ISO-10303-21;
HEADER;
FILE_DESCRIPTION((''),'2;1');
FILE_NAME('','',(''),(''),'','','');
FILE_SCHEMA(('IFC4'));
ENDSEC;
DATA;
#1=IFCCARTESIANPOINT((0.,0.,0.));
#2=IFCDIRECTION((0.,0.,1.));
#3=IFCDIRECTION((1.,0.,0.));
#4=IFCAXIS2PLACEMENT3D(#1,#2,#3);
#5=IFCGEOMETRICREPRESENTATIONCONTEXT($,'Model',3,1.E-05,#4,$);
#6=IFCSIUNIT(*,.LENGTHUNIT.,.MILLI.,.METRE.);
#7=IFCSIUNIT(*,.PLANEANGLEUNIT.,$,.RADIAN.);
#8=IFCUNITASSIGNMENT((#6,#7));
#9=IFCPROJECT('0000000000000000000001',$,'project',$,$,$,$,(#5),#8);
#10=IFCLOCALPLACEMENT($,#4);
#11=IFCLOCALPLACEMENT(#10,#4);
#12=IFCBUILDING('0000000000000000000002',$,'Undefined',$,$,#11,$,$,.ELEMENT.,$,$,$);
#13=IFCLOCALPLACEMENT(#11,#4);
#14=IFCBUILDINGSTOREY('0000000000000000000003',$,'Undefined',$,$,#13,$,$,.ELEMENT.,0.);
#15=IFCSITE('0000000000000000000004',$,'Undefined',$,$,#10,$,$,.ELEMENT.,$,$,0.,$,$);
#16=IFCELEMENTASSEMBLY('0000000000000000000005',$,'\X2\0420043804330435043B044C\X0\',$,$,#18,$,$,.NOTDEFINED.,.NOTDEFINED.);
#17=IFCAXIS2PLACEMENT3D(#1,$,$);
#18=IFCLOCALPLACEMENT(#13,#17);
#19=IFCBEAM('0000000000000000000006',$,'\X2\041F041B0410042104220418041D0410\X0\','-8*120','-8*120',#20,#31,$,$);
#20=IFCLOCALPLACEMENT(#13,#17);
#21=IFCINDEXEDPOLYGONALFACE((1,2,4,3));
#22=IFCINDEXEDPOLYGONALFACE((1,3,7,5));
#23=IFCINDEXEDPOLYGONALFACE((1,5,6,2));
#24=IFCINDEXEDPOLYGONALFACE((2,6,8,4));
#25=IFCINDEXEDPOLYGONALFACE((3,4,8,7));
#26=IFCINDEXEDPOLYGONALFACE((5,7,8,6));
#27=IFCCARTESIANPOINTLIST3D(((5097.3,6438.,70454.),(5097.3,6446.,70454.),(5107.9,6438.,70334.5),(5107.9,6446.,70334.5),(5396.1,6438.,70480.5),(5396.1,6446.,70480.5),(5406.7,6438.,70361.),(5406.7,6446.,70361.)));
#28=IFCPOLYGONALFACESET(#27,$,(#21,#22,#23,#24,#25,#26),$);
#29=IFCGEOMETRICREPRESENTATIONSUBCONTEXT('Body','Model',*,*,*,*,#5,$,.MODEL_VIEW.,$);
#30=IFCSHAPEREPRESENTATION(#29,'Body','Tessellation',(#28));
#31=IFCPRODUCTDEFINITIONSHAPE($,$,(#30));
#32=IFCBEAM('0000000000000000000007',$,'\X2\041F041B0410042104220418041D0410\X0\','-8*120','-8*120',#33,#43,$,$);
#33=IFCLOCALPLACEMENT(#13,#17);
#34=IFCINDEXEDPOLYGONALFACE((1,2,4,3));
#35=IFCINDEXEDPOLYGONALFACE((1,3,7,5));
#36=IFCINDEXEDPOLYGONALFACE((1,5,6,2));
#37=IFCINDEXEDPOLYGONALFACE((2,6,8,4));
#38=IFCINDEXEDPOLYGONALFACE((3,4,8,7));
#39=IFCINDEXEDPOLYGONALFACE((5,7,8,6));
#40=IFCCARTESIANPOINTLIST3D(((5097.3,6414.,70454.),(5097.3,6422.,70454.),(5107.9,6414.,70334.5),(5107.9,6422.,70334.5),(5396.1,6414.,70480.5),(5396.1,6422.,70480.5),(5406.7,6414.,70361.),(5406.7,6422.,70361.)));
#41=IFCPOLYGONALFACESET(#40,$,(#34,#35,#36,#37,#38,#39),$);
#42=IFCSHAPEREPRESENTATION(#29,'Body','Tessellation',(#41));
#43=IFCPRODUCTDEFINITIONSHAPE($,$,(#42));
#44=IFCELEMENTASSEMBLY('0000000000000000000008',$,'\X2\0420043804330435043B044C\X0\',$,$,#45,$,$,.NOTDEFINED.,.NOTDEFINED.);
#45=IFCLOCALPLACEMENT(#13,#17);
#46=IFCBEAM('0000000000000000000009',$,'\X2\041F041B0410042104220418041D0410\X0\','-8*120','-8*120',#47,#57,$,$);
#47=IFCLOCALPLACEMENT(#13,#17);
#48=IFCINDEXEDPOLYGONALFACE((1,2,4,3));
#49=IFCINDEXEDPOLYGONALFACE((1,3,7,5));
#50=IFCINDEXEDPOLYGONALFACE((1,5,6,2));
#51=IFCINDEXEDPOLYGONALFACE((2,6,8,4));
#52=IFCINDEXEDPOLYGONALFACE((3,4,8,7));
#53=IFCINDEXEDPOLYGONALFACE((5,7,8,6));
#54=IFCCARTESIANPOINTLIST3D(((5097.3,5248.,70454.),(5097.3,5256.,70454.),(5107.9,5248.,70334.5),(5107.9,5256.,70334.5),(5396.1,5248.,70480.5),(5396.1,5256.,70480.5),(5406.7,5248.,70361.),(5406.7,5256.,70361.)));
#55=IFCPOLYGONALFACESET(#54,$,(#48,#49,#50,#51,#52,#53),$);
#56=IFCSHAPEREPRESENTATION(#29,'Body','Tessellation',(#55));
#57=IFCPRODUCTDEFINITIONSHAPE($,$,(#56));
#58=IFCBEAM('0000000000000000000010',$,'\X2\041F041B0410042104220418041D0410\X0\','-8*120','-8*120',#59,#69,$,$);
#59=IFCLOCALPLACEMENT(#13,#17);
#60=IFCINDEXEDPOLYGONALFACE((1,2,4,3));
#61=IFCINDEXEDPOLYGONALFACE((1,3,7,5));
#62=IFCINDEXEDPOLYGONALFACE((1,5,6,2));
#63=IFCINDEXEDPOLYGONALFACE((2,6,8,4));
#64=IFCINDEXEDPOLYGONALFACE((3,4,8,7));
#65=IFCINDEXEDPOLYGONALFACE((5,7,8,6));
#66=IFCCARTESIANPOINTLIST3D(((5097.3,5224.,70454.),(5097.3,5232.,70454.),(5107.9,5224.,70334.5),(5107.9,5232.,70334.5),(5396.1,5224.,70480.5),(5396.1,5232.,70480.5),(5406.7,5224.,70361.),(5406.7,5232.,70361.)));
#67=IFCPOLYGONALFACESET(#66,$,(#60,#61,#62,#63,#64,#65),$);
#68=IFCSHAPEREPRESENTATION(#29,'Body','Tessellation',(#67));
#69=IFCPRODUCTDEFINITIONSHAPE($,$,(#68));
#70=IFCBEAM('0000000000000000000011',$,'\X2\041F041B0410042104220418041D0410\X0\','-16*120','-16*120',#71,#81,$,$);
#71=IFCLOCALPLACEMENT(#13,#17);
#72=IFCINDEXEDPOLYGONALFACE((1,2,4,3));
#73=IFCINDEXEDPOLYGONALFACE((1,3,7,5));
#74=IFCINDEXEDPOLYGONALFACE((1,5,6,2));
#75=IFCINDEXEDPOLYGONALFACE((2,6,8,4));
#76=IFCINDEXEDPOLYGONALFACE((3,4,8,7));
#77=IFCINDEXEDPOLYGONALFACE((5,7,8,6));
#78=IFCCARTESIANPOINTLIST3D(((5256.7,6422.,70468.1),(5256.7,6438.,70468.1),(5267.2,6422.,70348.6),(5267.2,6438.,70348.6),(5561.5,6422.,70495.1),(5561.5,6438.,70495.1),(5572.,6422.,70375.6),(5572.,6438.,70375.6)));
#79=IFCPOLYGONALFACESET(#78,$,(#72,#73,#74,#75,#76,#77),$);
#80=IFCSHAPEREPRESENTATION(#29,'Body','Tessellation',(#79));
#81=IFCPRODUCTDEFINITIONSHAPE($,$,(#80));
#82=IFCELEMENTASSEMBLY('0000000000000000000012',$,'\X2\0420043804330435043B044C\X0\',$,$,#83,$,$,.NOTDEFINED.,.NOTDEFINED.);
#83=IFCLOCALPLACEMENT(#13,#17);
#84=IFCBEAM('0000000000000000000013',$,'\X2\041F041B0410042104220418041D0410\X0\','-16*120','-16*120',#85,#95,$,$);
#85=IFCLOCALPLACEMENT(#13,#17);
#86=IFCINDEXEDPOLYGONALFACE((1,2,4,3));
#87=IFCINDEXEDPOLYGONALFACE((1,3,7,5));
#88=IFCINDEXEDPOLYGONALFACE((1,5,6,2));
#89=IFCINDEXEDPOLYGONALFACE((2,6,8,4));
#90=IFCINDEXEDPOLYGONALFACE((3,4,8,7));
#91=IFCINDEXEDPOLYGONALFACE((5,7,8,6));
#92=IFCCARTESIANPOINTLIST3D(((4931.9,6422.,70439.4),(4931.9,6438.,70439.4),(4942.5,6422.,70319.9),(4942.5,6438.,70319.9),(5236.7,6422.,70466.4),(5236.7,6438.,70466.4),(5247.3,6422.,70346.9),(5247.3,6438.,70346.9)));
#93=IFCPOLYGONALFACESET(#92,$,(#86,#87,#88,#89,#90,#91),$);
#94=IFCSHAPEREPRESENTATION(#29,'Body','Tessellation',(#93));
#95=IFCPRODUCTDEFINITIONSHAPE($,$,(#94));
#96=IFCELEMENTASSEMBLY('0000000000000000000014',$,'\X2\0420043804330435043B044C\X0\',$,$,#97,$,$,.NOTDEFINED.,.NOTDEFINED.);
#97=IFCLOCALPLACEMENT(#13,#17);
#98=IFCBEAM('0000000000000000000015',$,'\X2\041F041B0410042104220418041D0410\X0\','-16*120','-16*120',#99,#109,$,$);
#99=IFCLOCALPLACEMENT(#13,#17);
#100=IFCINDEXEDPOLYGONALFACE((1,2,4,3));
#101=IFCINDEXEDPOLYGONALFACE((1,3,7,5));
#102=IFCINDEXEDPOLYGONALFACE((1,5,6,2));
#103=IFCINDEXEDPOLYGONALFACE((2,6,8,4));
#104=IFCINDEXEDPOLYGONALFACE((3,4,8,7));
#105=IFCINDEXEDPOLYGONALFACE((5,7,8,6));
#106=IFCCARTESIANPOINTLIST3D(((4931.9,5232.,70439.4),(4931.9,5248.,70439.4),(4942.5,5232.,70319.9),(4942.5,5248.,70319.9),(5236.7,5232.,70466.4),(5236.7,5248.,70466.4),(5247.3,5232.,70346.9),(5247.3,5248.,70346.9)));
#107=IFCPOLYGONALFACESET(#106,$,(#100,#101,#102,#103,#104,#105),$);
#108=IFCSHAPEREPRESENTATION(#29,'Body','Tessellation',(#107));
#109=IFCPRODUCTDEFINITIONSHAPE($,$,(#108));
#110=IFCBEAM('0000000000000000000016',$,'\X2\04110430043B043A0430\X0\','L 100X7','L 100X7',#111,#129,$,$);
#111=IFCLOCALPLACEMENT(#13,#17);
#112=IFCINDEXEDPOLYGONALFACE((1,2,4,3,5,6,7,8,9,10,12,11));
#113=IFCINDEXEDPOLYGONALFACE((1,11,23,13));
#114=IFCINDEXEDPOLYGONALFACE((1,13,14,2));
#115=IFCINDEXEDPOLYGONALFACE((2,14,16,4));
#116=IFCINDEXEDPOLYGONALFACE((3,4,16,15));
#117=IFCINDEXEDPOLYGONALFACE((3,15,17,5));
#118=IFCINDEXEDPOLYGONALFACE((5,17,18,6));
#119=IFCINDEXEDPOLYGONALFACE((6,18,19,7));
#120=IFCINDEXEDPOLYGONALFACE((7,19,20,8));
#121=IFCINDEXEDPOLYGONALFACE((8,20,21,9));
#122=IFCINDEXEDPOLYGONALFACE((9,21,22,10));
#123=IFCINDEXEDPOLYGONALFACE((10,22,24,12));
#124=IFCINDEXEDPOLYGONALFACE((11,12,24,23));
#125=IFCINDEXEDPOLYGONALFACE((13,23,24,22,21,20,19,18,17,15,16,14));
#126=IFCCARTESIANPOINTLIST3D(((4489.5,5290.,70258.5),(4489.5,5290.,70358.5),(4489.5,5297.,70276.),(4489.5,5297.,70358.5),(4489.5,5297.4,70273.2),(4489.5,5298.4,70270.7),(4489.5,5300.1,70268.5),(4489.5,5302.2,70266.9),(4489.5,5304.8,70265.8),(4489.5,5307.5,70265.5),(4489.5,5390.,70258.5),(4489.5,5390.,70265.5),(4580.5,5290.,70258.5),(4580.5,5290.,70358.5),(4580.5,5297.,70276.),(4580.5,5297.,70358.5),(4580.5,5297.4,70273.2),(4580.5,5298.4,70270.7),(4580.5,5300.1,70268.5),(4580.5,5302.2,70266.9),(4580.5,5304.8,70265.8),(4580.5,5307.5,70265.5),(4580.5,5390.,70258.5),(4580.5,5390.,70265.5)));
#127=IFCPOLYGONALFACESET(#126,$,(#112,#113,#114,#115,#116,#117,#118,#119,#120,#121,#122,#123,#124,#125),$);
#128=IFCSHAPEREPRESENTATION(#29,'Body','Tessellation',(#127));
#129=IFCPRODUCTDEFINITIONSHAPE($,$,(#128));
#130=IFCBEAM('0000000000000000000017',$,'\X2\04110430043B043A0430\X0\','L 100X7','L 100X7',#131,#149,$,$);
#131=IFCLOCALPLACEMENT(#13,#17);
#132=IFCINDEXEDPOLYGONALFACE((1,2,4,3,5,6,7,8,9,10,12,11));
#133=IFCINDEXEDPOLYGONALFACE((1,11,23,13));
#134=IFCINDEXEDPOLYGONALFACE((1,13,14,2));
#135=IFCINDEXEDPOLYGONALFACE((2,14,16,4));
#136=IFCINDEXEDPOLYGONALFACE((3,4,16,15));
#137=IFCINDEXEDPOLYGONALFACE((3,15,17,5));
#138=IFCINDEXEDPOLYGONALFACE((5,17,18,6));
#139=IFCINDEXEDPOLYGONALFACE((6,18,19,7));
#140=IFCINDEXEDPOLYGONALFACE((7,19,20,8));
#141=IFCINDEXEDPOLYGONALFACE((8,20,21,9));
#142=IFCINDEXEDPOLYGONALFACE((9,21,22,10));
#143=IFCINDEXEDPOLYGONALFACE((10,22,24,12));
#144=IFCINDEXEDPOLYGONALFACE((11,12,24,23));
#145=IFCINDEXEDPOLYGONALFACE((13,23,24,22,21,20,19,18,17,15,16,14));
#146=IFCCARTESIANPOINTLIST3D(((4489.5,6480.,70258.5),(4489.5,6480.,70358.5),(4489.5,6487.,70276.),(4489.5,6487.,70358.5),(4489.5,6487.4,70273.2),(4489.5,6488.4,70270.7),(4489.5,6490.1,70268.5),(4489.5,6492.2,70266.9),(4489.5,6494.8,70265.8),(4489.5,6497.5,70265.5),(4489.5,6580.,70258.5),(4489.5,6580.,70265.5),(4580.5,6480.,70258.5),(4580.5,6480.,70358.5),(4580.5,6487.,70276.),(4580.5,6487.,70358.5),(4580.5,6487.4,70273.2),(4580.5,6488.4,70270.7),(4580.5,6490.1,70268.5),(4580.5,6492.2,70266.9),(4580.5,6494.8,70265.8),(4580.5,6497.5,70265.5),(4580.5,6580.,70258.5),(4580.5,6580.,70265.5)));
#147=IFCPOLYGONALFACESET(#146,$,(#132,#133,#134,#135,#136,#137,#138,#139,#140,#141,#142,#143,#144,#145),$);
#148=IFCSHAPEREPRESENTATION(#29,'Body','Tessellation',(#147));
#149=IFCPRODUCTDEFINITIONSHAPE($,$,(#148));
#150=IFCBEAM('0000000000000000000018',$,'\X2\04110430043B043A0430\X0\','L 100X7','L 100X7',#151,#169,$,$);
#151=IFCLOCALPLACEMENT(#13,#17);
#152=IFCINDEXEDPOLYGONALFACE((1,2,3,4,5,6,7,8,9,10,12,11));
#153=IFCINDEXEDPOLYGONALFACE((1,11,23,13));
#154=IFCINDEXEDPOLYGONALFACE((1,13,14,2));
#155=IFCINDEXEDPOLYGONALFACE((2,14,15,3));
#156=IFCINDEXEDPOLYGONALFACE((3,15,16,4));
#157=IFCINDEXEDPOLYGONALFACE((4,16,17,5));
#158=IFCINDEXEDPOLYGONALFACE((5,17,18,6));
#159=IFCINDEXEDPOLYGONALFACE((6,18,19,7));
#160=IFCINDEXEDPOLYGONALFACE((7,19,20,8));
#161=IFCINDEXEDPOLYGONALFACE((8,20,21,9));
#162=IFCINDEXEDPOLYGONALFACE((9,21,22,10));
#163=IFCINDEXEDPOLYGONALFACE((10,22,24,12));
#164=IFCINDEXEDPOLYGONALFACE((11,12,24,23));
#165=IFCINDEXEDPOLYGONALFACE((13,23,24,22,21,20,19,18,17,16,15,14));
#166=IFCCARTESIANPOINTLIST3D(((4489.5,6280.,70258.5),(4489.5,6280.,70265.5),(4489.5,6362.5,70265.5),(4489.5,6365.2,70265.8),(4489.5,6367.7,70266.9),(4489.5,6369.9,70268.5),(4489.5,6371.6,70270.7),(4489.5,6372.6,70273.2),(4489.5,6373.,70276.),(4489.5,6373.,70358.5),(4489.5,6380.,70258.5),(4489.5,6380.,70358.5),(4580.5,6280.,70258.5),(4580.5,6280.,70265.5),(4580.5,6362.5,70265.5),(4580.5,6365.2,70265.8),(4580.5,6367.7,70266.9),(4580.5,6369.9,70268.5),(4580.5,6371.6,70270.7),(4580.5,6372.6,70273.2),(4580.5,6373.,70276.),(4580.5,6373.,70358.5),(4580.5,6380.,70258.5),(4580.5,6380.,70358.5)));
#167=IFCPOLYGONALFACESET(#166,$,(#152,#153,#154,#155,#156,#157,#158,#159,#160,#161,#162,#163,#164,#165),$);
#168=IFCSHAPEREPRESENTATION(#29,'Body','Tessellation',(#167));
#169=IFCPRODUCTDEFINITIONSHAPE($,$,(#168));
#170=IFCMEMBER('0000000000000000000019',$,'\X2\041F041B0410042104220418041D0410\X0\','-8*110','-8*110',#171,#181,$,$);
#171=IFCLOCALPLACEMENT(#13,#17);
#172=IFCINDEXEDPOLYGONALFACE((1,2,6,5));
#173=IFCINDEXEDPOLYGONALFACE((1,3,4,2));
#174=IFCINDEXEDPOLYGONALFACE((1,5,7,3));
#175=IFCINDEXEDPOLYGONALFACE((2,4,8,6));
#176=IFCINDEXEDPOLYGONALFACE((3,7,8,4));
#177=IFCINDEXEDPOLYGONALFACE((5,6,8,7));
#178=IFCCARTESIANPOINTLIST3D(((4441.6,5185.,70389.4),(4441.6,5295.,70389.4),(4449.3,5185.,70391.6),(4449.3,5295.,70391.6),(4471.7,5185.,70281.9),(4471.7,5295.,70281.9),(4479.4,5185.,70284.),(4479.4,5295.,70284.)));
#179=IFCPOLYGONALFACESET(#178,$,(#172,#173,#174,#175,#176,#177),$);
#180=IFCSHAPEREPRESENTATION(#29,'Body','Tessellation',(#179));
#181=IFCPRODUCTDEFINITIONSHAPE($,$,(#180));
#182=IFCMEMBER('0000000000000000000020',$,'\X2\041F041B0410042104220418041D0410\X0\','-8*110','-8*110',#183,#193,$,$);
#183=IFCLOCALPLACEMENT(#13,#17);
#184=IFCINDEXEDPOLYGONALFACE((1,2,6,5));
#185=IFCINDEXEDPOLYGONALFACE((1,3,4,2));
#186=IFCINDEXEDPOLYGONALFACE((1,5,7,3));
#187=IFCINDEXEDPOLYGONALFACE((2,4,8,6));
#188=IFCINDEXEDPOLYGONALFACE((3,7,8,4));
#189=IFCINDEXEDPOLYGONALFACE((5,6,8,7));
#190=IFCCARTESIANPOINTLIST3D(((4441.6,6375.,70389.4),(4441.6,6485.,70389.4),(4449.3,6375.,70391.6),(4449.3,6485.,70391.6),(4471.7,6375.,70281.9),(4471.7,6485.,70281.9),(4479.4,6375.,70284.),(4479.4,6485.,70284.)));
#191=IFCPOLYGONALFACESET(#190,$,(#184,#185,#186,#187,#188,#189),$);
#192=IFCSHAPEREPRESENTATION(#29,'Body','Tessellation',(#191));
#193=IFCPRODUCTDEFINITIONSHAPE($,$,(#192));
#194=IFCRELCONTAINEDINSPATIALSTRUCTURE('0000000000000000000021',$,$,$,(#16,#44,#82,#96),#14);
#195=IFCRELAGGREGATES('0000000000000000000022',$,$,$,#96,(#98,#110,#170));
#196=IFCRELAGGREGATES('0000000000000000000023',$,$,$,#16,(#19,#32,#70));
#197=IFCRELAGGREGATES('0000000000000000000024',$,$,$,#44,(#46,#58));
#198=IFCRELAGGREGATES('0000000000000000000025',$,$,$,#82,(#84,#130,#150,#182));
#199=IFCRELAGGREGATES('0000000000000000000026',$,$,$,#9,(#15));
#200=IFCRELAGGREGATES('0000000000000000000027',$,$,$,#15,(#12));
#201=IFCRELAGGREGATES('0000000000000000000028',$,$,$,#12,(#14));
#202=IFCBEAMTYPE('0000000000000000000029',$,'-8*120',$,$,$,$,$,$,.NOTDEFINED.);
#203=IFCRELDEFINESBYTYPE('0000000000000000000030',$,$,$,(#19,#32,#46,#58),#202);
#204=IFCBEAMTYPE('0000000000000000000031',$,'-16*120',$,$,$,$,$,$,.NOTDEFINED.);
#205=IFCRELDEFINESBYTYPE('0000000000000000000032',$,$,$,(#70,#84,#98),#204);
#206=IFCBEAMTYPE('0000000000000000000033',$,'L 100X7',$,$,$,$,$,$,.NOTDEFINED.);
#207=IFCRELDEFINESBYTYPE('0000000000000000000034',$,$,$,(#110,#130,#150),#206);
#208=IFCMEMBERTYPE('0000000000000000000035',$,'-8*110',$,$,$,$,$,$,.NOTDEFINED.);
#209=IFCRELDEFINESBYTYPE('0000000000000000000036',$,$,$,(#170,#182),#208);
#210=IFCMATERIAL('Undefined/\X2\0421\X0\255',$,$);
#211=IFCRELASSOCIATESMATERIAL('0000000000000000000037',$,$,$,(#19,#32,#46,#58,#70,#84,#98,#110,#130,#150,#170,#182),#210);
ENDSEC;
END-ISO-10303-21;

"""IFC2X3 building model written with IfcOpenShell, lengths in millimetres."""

from ifc_helpers import new_model, si_unit, frame, origin_with_axes, origin_2d_with_axis, place, context, subcontext, project, spatial, rectangle, l_section, extrude, material, type_object, element, aggregate, save


model = new_model("IFC2X3")

# Units and contexts
model_context = context("Model", 3, precision=1e-05, world=origin_with_axes())
body_context = subcontext(model_context, "Body", "Model", "MODEL_VIEW")
ifc_project = project(units=[si_unit("LENGTHUNIT", "METRE", prefix="MILLI"), si_unit("PLANEANGLEUNIT", "RADIAN")], contexts=[model_context])

# Site, building, storey
site_placement = place(None, origin_with_axes())
site = spatial("IfcSite", under=ifc_project, at=site_placement, Name="Undefined", CompositionType="ELEMENT", RefElevation=0.0)
building_placement = place(site_placement, origin_with_axes())
building = spatial("IfcBuilding", under=site, at=building_placement, Name="Undefined", CompositionType="ELEMENT")
storey_placement = place(building_placement, origin_with_axes())
storey = spatial("IfcBuildingStorey", under=building, at=storey_placement, Name="Undefined", CompositionType="ELEMENT", Elevation=0.0)

# Element assemblies, beams
assembly_1_placement = place(storey_placement, origin_with_axes())
assembly_1 = element("IfcElementAssembly", 1, at=assembly_1_placement, inside=storey, Name="Ригель", AssemblyPlace="NOTDEFINED", PredefinedType="NOTDEFINED")
ifc_material_1 = material(Name="Undefined/С255")
beam_type_1 = type_object("IfcBeamType", Name="-8*120", PredefinedType="NOTDEFINED")
beam_1_placement = place(assembly_1_placement, frame((5102.6, 6442.0, 70394.3), z_axis=(0.088152, 0.0, -0.996107), x_axis=(0.996107, 0.0, 0.088152)))
beam_1 = element("IfcBeam", 2, at=beam_1_placement, type_object=beam_type_1, material=ifc_material_1, Name="ПЛАСТИНА", Description="-8*120", ObjectType="-8*120", context=body_context, shape_type="SweptSolid", body=[
    extrude(rectangle(XDim=8.0, YDim=120.0, at=origin_2d_with_axis()), frame((300.0, 0.0, 0.0), z_axis=(-1.0, 0.0, 0.0), x_axis=(0.0, -1.0, 0.0)), (0.0, 0.0, 1.0), 300.0),
])
beam_2_placement = place(assembly_1_placement, frame((5102.6, 6418.0, 70394.3), z_axis=(0.088152, 0.0, -0.996107), x_axis=(0.996107, 0.0, 0.088152)))
beam_2 = element("IfcBeam", 3, at=beam_2_placement, type_object=beam_type_1, material=ifc_material_1, Name="ПЛАСТИНА", Description="-8*120", ObjectType="-8*120", context=body_context, shape_type="SweptSolid", body=[
    extrude(rectangle(XDim=8.0, YDim=120.0, at=origin_2d_with_axis()), frame((300.0, 0.0, 0.0), z_axis=(-1.0, 0.0, 0.0), x_axis=(0.0, -1.0, 0.0)), (0.0, 0.0, 1.0), 300.0),
])
assembly_2_placement = place(storey_placement, origin_with_axes())
assembly_2 = element("IfcElementAssembly", 4, at=assembly_2_placement, inside=storey, Name="Ригель", AssemblyPlace="NOTDEFINED", PredefinedType="NOTDEFINED")
beam_3_placement = place(assembly_2_placement, frame((5102.6, 5252.0, 70394.3), z_axis=(0.088152, 0.0, -0.996107), x_axis=(0.996107, 0.0, 0.088152)))
beam_3 = element("IfcBeam", 5, at=beam_3_placement, type_object=beam_type_1, material=ifc_material_1, Name="ПЛАСТИНА", Description="-8*120", ObjectType="-8*120", context=body_context, shape_type="SweptSolid", body=[
    extrude(rectangle(XDim=8.0, YDim=120.0, at=origin_2d_with_axis()), frame((300.0, 0.0, 0.0), z_axis=(-1.0, 0.0, 0.0), x_axis=(0.0, -1.0, 0.0)), (0.0, 0.0, 1.0), 300.0),
])
beam_4_placement = place(assembly_2_placement, frame((5102.6, 5228.0, 70394.3), z_axis=(0.088152, 0.0, -0.996107), x_axis=(0.996107, 0.0, 0.088152)))
beam_4 = element("IfcBeam", 6, at=beam_4_placement, type_object=beam_type_1, material=ifc_material_1, Name="ПЛАСТИНА", Description="-8*120", ObjectType="-8*120", context=body_context, shape_type="SweptSolid", body=[
    extrude(rectangle(XDim=8.0, YDim=120.0, at=origin_2d_with_axis()), frame((300.0, 0.0, 0.0), z_axis=(-1.0, 0.0, 0.0), x_axis=(0.0, -1.0, 0.0)), (0.0, 0.0, 1.0), 300.0),
])

# Beam
beam_type_2 = type_object("IfcBeamType", Name="-16*120", PredefinedType="NOTDEFINED")
beam_5_placement = place(assembly_1_placement, frame((5261.9, 6430.0, 70408.4), z_axis=(0.088152, 0.0, -0.996107), x_axis=(0.996107, 0.0, 0.088152)))
beam_5 = element("IfcBeam", 7, at=beam_5_placement, type_object=beam_type_2, material=ifc_material_1, Name="ПЛАСТИНА", Description="-16*120", ObjectType="-16*120", context=body_context, shape_type="SweptSolid", body=[
    extrude(rectangle(XDim=16.0, YDim=120.0, at=origin_2d_with_axis()), frame((306.0, 0.0, 0.0), z_axis=(-1.0, 0.0, 0.0), x_axis=(0.0, -1.0, 0.0)), (0.0, 0.0, 1.0), 306.0),
])

# Element assembly, beam
assembly_3_placement = place(storey_placement, origin_with_axes())
assembly_3 = element("IfcElementAssembly", 8, at=assembly_3_placement, inside=storey, Name="Ригель", AssemblyPlace="NOTDEFINED", PredefinedType="NOTDEFINED")
beam_6_placement = place(assembly_3_placement, frame((4937.2, 6430.0, 70379.6), z_axis=(0.088152, 0.0, -0.996107), x_axis=(0.996107, 0.0, 0.088152)))
beam_6 = element("IfcBeam", 9, at=beam_6_placement, type_object=beam_type_2, material=ifc_material_1, Name="ПЛАСТИНА", Description="-16*120", ObjectType="-16*120", context=body_context, shape_type="SweptSolid", body=[
    extrude(rectangle(XDim=16.0, YDim=120.0, at=origin_2d_with_axis()), frame((306.0, 0.0, 0.0), z_axis=(-1.0, 0.0, 0.0), x_axis=(0.0, -1.0, 0.0)), (0.0, 0.0, 1.0), 306.0),
])

# Element assembly, beams
assembly_4_placement = place(storey_placement, origin_with_axes())
assembly_4 = element("IfcElementAssembly", 10, at=assembly_4_placement, inside=storey, Name="Ригель", AssemblyPlace="NOTDEFINED", PredefinedType="NOTDEFINED")
beam_7_placement = place(assembly_4_placement, frame((4937.2, 5240.0, 70379.6), z_axis=(0.088152, 0.0, -0.996107), x_axis=(0.996107, 0.0, 0.088152)))
beam_7 = element("IfcBeam", 11, at=beam_7_placement, type_object=beam_type_2, material=ifc_material_1, Name="ПЛАСТИНА", Description="-16*120", ObjectType="-16*120", context=body_context, shape_type="SweptSolid", body=[
    extrude(rectangle(XDim=16.0, YDim=120.0, at=origin_2d_with_axis()), frame((306.0, 0.0, 0.0), z_axis=(-1.0, 0.0, 0.0), x_axis=(0.0, -1.0, 0.0)), (0.0, 0.0, 1.0), 306.0),
])
beam_type_3 = type_object("IfcBeamType", Name="L 100X7", PredefinedType="NOTDEFINED")
beam_8_placement = place(assembly_4_placement, frame((4489.5, 5340.0, 70308.5), z_axis=(0.0, 1.0, 0.0), x_axis=(1.0, 0.0, 0.0)))
beam_8 = element("IfcBeam", 12, at=beam_8_placement, type_object=beam_type_3, material=ifc_material_1, Name="Балка", Description="L 100X7", ObjectType="L 100X7", context=body_context, shape_type="SweptSolid", body=[
    extrude(l_section(Depth=100.0, Width=100.0, Thickness=7.0, FilletRadius=10.5, at=origin_2d_with_axis()), frame((91.0, 0.0, 0.0), z_axis=(-1.0, 0.0, 0.0), x_axis=(0.0, -1.0, 0.0)), (0.0, 0.0, 1.0), 91.0),
])

# Beams
beam_9_placement = place(assembly_3_placement, frame((4489.5, 6530.0, 70308.5), z_axis=(0.0, 1.0, 0.0), x_axis=(1.0, 0.0, 0.0)))
beam_9 = element("IfcBeam", 13, at=beam_9_placement, type_object=beam_type_3, material=ifc_material_1, Name="Балка", Description="L 100X7", ObjectType="L 100X7", context=body_context, shape_type="SweptSolid", body=[
    extrude(l_section(Depth=100.0, Width=100.0, Thickness=7.0, FilletRadius=10.5, at=origin_2d_with_axis()), frame((91.0, 0.0, 0.0), z_axis=(-1.0, 0.0, 0.0), x_axis=(0.0, -1.0, 0.0)), (0.0, 0.0, 1.0), 91.0),
])
beam_10_placement = place(assembly_3_placement, frame((4489.5, 6330.0, 70308.5), z_axis=(0.0, 0.0, 1.0), x_axis=(1.0, 0.0, 0.0)))
beam_10 = element("IfcBeam", 14, at=beam_10_placement, type_object=beam_type_3, material=ifc_material_1, Name="Балка", Description="L 100X7", ObjectType="L 100X7", context=body_context, shape_type="SweptSolid", body=[
    extrude(l_section(Depth=100.0, Width=100.0, Thickness=7.0, FilletRadius=10.5, at=origin_2d_with_axis()), frame((91.0, 0.0, 0.0), z_axis=(-1.0, 0.0, 0.0), x_axis=(0.0, -1.0, 0.0)), (0.0, 0.0, 1.0), 91.0),
])

# Members
member_type = type_object("IfcMemberType", Name="-8*110", PredefinedType="NOTDEFINED")
member_1_placement = place(assembly_4_placement, frame((4475.6, 5240.0, 70282.9), z_axis=(0.0, -1.0, 0.0), x_axis=(-0.269248, 0.0, 0.963071)))
member_1 = element("IfcMember", 15, at=member_1_placement, type_object=member_type, material=ifc_material_1, Name="ПЛАСТИНА", Description="-8*110", ObjectType="-8*110", context=body_context, shape_type="SweptSolid", body=[
    extrude(rectangle(XDim=8.0, YDim=110.0, at=origin_2d_with_axis()), frame((111.7, 0.0, 0.0), z_axis=(-1.0, 0.0, 0.0), x_axis=(0.0, -1.0, 0.0)), (0.0, 0.0, 1.0), 111.7),
])
aggregate(assembly_4, [beam_7, beam_8, member_1])
member_2_placement = place(assembly_3_placement, frame((4475.6, 6430.0, 70282.9), z_axis=(0.0, -1.0, 0.0), x_axis=(-0.269248, 0.0, 0.963071)))
member_2 = element("IfcMember", 16, at=member_2_placement, type_object=member_type, material=ifc_material_1, Name="ПЛАСТИНА", Description="-8*110", ObjectType="-8*110", context=body_context, shape_type="SweptSolid", body=[
    extrude(rectangle(XDim=8.0, YDim=110.0, at=origin_2d_with_axis()), frame((111.7, 0.0, 0.0), z_axis=(-1.0, 0.0, 0.0), x_axis=(0.0, -1.0, 0.0)), (0.0, 0.0, 1.0), 111.7),
])

aggregate(assembly_1, [beam_1, beam_2, beam_5])
aggregate(assembly_2, [beam_3, beam_4])
aggregate(assembly_3, [beam_6, beam_9, beam_10, member_2])

save(model, "model.ifc")
